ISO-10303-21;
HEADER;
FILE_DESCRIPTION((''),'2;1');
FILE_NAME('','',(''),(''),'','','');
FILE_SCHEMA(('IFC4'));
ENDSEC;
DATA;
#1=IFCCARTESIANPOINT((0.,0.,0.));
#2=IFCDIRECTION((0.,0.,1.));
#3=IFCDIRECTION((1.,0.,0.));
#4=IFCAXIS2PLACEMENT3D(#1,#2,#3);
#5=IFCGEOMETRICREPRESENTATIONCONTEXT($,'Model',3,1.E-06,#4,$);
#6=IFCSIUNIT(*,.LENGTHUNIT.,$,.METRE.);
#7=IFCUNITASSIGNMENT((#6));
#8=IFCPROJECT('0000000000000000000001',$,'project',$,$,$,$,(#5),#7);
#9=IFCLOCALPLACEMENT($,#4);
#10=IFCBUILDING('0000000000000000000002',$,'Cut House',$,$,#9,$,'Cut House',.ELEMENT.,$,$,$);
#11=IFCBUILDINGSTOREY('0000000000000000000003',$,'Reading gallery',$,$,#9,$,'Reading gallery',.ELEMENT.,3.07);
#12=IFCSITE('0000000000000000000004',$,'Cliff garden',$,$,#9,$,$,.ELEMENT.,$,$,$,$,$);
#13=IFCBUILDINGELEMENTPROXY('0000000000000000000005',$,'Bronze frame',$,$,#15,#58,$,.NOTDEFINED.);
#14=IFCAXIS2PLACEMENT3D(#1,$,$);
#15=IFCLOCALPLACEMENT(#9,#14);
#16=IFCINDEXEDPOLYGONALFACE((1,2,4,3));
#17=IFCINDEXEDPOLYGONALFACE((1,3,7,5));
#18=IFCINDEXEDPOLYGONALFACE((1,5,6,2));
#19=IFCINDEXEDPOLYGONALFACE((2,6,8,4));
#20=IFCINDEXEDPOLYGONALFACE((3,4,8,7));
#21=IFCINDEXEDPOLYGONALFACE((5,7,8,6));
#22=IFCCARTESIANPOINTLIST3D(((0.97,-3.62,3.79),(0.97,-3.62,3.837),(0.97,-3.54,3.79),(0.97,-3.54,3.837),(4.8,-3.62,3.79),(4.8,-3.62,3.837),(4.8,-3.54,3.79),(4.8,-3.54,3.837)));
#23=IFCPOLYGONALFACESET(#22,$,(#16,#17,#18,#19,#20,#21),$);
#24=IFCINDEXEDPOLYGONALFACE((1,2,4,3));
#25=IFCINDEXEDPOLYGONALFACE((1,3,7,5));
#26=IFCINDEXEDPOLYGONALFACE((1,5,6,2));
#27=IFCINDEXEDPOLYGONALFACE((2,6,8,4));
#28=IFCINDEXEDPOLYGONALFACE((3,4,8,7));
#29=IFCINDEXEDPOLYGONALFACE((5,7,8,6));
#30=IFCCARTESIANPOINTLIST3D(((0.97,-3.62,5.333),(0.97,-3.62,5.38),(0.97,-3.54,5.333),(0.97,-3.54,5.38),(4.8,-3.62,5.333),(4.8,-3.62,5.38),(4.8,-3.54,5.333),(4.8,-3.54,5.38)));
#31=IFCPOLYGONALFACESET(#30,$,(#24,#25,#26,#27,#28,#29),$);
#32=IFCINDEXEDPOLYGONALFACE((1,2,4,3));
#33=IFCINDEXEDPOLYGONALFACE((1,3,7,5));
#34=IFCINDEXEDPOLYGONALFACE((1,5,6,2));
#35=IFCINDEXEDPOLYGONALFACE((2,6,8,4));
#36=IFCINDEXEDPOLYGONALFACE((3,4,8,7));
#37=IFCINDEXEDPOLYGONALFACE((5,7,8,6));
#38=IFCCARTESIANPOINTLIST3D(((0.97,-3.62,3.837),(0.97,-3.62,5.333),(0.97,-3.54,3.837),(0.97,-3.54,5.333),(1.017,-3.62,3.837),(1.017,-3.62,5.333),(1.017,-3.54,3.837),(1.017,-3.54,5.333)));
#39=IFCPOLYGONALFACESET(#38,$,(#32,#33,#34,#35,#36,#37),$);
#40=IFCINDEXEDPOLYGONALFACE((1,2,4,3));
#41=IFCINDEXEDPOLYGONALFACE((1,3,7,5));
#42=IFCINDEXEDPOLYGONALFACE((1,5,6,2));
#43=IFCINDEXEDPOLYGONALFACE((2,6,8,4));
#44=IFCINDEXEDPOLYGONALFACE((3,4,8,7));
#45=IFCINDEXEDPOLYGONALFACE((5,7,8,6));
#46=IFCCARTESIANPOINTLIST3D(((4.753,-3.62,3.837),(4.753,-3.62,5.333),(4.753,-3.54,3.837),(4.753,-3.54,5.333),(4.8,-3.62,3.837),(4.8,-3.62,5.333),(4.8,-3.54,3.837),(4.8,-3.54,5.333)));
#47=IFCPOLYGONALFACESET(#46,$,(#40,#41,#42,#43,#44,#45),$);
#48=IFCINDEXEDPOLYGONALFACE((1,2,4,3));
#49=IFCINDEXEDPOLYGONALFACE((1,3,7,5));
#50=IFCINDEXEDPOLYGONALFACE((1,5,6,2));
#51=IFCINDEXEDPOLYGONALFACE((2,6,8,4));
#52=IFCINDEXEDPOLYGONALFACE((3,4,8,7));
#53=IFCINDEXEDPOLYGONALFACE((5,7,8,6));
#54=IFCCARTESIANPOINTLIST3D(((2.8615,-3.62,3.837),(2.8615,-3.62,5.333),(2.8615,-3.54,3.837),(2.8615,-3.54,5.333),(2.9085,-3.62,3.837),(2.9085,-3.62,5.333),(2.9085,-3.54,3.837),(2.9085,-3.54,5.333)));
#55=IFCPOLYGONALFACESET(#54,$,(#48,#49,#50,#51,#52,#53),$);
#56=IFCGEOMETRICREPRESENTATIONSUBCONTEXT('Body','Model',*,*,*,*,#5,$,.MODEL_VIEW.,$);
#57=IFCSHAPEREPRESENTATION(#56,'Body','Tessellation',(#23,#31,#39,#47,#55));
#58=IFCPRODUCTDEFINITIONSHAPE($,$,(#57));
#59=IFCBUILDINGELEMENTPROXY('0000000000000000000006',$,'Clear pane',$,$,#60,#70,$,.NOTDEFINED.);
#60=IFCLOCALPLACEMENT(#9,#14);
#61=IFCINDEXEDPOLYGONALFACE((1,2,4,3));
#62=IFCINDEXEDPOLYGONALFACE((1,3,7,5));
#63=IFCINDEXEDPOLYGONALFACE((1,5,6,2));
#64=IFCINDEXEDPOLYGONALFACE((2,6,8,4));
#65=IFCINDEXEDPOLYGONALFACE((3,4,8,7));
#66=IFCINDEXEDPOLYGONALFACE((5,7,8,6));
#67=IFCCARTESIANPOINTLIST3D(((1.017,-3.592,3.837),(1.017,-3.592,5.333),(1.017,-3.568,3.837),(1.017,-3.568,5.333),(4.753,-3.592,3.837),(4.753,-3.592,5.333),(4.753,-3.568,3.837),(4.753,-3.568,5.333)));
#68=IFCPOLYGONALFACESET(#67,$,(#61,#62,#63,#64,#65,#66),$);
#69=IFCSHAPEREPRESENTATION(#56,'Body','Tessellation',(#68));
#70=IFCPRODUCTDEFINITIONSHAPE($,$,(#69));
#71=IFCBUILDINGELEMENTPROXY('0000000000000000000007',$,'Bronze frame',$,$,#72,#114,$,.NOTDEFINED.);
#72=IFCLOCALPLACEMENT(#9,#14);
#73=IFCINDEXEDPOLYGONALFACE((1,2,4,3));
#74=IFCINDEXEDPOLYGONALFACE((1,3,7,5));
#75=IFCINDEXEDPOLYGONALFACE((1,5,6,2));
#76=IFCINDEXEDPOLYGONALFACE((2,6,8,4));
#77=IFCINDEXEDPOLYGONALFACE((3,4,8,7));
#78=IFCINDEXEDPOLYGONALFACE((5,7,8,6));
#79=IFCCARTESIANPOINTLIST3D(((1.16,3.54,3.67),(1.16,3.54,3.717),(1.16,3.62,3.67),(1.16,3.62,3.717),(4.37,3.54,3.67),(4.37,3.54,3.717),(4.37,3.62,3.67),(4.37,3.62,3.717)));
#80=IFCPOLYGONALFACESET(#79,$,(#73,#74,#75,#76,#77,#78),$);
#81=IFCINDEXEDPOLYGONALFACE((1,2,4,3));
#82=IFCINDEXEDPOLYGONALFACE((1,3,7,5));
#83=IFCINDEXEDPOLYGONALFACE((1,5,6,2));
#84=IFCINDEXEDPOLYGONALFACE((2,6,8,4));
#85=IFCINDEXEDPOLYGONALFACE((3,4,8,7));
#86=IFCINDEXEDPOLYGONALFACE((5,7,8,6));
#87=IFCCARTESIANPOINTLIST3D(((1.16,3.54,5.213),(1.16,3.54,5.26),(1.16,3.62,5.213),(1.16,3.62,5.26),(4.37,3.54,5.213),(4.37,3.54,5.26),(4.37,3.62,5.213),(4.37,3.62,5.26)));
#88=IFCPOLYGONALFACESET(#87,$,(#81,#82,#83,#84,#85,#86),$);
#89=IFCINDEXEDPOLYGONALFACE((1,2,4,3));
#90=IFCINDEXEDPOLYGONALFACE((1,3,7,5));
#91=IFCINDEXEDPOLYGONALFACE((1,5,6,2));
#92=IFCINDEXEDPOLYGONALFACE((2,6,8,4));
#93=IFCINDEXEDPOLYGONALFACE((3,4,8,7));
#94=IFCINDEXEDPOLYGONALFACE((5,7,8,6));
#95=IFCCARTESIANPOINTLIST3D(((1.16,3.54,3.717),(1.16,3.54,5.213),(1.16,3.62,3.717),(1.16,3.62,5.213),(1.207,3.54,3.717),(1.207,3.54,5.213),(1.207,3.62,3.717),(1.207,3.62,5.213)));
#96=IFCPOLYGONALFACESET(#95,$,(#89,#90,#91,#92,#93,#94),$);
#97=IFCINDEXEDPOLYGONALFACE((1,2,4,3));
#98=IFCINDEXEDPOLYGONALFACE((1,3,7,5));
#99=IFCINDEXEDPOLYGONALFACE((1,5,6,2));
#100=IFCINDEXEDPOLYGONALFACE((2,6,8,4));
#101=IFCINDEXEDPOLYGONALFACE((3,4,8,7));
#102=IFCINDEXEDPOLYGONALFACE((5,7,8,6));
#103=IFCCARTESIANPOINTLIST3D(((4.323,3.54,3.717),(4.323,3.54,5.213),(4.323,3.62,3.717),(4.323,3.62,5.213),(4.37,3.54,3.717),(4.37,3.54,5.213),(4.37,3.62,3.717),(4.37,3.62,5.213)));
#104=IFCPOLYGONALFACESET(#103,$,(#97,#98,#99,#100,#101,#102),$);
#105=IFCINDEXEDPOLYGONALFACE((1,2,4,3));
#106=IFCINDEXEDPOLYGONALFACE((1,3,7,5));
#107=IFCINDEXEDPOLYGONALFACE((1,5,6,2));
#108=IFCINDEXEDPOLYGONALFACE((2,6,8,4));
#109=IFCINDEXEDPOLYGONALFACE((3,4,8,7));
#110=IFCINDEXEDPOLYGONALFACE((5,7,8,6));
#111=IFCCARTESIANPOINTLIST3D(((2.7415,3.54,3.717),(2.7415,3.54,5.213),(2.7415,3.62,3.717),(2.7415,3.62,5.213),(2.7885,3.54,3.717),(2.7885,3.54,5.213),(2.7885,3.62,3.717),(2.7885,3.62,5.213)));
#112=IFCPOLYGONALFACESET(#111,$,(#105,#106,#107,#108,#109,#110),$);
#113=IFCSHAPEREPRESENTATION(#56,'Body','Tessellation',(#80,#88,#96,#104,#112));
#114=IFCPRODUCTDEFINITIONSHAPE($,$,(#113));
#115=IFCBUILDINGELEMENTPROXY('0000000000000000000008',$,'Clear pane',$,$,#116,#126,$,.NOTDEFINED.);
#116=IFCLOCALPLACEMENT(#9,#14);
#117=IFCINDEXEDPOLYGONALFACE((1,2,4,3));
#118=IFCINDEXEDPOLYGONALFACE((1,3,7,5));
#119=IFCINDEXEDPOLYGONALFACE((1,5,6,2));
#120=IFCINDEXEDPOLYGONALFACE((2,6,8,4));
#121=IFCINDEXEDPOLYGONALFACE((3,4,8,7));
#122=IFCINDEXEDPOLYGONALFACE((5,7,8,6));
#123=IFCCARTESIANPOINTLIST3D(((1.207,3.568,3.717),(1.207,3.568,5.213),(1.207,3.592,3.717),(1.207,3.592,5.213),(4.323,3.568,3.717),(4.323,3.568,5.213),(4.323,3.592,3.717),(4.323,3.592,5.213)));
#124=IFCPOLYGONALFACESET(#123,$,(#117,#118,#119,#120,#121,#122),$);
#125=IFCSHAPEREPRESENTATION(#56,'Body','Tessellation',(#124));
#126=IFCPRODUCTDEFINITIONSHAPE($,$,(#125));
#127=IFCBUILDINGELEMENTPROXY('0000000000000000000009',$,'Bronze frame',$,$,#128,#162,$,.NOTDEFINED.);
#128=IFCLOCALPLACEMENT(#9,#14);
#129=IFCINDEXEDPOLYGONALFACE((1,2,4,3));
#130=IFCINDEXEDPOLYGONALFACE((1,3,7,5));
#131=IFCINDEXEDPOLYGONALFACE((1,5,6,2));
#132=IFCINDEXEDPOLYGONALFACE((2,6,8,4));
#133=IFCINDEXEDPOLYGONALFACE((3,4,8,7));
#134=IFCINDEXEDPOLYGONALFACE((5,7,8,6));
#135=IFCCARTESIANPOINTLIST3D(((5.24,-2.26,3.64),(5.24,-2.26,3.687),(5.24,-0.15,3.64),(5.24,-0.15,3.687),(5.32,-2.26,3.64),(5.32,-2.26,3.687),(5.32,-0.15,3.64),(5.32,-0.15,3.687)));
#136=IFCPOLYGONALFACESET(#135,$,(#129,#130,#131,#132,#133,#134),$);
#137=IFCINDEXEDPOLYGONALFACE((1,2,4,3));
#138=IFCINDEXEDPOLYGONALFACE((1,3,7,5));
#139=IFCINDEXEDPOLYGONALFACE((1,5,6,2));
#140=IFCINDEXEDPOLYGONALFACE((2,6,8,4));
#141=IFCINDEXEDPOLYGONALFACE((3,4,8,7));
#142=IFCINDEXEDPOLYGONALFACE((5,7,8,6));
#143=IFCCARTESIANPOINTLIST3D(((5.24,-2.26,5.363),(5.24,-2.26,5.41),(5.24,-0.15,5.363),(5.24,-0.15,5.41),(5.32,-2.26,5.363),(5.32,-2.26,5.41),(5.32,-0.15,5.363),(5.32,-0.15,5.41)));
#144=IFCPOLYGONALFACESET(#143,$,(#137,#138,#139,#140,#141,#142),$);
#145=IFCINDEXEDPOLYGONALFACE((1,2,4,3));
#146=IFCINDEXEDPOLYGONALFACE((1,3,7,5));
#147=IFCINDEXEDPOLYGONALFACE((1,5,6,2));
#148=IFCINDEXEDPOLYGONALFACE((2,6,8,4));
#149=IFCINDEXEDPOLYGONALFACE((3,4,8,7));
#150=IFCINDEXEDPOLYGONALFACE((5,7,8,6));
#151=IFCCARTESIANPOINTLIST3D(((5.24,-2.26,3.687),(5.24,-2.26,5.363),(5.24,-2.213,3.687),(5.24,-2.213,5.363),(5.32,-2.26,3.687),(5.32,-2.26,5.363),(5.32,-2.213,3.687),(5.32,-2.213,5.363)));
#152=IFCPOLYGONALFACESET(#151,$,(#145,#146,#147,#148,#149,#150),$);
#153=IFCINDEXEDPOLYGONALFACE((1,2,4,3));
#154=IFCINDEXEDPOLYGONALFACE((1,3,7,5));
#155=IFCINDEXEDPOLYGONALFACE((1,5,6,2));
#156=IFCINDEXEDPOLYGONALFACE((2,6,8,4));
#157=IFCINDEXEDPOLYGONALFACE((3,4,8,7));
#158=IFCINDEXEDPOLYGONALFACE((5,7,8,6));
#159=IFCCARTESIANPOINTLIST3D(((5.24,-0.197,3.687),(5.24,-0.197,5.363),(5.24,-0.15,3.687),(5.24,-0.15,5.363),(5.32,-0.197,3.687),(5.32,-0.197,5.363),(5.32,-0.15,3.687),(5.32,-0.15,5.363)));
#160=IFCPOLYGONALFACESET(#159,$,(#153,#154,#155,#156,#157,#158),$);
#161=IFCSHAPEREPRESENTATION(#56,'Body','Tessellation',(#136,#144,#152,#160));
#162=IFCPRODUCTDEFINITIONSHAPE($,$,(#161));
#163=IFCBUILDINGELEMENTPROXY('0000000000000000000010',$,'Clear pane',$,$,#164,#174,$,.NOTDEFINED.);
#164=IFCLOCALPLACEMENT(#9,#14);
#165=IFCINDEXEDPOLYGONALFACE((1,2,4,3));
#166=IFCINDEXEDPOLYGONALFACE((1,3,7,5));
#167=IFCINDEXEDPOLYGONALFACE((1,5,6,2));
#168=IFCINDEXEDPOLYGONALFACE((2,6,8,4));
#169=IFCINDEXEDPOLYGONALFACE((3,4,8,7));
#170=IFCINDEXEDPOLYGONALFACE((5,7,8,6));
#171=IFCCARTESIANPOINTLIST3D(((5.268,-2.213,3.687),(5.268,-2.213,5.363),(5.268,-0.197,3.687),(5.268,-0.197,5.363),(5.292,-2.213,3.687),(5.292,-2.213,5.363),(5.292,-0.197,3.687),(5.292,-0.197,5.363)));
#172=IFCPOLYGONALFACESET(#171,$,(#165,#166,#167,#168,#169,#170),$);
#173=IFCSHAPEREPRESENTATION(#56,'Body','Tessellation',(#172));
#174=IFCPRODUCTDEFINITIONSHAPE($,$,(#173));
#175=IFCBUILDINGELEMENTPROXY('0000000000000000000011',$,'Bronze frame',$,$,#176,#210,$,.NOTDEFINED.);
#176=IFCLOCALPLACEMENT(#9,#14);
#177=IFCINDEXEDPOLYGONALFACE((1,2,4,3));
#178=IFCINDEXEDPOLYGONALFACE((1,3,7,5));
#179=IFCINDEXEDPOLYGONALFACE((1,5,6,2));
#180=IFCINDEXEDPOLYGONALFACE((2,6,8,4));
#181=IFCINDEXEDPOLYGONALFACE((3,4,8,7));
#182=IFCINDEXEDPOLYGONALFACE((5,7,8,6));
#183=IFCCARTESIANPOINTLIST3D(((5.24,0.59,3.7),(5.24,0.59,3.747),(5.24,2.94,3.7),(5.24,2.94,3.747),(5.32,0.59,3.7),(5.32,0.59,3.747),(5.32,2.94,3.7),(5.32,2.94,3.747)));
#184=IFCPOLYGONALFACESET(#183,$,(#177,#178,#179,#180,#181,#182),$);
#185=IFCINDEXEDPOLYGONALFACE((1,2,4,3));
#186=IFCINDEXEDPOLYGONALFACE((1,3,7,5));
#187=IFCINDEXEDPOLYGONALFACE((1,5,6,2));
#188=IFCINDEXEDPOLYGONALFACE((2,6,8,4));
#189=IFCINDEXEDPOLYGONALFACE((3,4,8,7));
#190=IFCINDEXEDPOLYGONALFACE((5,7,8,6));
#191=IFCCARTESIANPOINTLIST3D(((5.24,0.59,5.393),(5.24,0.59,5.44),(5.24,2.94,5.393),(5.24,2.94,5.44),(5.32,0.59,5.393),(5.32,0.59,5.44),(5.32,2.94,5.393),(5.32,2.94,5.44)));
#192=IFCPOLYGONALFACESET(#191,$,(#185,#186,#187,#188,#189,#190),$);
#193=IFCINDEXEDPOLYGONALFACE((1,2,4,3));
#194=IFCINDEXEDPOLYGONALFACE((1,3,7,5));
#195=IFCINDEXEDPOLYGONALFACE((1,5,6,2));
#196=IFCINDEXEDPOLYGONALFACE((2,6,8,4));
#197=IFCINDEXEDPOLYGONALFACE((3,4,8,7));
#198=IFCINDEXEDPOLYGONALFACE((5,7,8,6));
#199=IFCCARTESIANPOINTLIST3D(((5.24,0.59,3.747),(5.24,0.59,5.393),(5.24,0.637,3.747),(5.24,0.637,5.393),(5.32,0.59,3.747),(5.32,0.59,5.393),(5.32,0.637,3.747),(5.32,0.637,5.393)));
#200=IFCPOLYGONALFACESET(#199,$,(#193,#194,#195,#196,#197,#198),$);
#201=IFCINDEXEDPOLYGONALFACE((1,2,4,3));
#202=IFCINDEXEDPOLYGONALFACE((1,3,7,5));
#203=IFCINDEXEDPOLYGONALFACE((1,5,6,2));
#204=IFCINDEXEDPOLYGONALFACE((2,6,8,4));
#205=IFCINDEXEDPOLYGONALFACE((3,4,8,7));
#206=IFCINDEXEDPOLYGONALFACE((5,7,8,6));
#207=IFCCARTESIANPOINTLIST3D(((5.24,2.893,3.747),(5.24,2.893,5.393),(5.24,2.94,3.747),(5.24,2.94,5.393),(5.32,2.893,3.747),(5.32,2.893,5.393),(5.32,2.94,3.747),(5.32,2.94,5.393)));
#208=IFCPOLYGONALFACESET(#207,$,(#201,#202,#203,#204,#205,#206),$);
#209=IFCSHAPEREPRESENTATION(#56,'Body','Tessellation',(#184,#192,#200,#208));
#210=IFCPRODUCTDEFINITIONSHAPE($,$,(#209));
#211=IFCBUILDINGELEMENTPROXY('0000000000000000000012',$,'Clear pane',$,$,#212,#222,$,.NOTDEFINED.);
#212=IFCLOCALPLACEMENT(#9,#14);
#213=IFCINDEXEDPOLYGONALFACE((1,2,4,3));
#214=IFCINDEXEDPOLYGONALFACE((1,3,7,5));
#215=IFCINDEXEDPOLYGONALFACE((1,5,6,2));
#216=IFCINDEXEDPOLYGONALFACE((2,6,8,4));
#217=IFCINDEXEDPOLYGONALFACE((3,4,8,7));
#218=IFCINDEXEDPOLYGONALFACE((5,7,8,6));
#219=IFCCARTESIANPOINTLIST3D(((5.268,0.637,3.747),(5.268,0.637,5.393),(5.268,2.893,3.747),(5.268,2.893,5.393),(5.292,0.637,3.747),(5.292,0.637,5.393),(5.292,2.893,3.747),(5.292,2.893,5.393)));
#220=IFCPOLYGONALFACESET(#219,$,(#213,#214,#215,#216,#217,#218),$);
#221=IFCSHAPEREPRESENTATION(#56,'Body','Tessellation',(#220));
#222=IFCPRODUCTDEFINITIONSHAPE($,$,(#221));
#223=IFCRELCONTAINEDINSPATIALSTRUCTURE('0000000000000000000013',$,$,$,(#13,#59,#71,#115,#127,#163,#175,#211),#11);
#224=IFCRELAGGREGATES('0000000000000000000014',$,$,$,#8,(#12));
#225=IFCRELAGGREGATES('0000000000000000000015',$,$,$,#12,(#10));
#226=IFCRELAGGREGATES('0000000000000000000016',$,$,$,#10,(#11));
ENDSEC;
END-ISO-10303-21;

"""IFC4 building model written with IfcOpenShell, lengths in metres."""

from ifc_helpers import new_model, si_unit, frame, origin_with_axes, place, context, subcontext, project, spatial, polyline, outline, extrude, element, save


model = new_model("IFC4")

# Units and contexts
model_context = context("Model", 3, precision=1e-06, world=origin_with_axes())
body_context = subcontext(model_context, "Body", "Model", "MODEL_VIEW")
ifc_project = project(units=[si_unit("LENGTHUNIT", "METRE")], contexts=[model_context])

# Site, building, storey
placement = place(None, origin_with_axes())
site = spatial("IfcSite", under=ifc_project, at=placement, Name="Cliff garden", CompositionType="ELEMENT")
building = spatial("IfcBuilding", under=site, at=placement, Name="Cut House", LongName="Cut House", CompositionType="ELEMENT")
storey = spatial("IfcBuildingStorey", under=building, at=placement, Name="Reading gallery", LongName="Reading gallery", CompositionType="ELEMENT", Elevation=3.07)

# Building element proxies
element("IfcBuildingElementProxy", 1, at=placement, inside=storey, Name="Bronze frame", PredefinedType="NOTDEFINED", context=body_context, shape_type="SweptSolid", body=[
    extrude(outline(polyline([(0.0, 0.0), (3.83, 0.0), (3.83, 0.08), (0.0, 0.08), (0.0, 0.0)])), frame((0.97, -3.62, 3.79), z_axis=(0.0, 0.0, 1.0), x_axis=(1.0, 0.0, 0.0)), (0.0, 0.0, 1.0), 0.047),
    extrude(outline(polyline([(0.0, 0.0), (3.83, 0.0), (3.83, 0.08), (0.0, 0.08), (0.0, 0.0)])), frame((0.97, -3.62, 5.333), z_axis=(0.0, 0.0, 1.0), x_axis=(1.0, 0.0, 0.0)), (0.0, 0.0, 1.0), 0.047),
    extrude(outline(polyline([(0.0, 0.0), (0.047, 0.0), (0.047, 0.08), (0.0, 0.08), (0.0, 0.0)])), frame((0.97, -3.62, 3.837), z_axis=(0.0, 0.0, 1.0), x_axis=(1.0, 0.0, 0.0)), (0.0, 0.0, 1.0), 1.496),
    extrude(outline(polyline([(0.0, 0.0), (0.047, 0.0), (0.047, 0.08), (0.0, 0.08), (0.0, 0.0)])), frame((4.753, -3.62, 3.837), z_axis=(0.0, 0.0, 1.0), x_axis=(1.0, 0.0, 0.0)), (0.0, 0.0, 1.0), 1.496),
    extrude(outline(polyline([(0.0, 0.0), (0.047, 0.0), (0.047, 0.08), (0.0, 0.08), (0.0, 0.0)])), frame((2.8615, -3.62, 3.837), z_axis=(0.0, 0.0, 1.0), x_axis=(1.0, 0.0, 0.0)), (0.0, 0.0, 1.0), 1.496),
])
element("IfcBuildingElementProxy", 2, at=placement, inside=storey, Name="Clear pane", PredefinedType="NOTDEFINED", context=body_context, shape_type="SweptSolid", body=[
    extrude(outline(polyline([(0.0, 0.0), (3.736, 0.0), (3.736, 0.024), (0.0, 0.024), (0.0, 0.0)])), frame((1.017, -3.592, 3.837), z_axis=(0.0, 0.0, 1.0), x_axis=(1.0, 0.0, 0.0)), (0.0, 0.0, 1.0), 1.496),
])
element("IfcBuildingElementProxy", 3, at=placement, inside=storey, Name="Bronze frame", PredefinedType="NOTDEFINED", context=body_context, shape_type="SweptSolid", body=[
    extrude(outline(polyline([(0.0, 0.0), (3.21, 0.0), (3.21, 0.08), (0.0, 0.08), (0.0, 0.0)])), frame((1.16, 3.54, 3.67), z_axis=(0.0, 0.0, 1.0), x_axis=(1.0, 0.0, 0.0)), (0.0, 0.0, 1.0), 0.047),
    extrude(outline(polyline([(0.0, 0.0), (3.21, 0.0), (3.21, 0.08), (0.0, 0.08), (0.0, 0.0)])), frame((1.16, 3.54, 5.213), z_axis=(0.0, 0.0, 1.0), x_axis=(1.0, 0.0, 0.0)), (0.0, 0.0, 1.0), 0.047),
    extrude(outline(polyline([(0.0, 0.0), (0.047, 0.0), (0.047, 0.08), (0.0, 0.08), (0.0, 0.0)])), frame((1.16, 3.54, 3.717), z_axis=(0.0, 0.0, 1.0), x_axis=(1.0, 0.0, 0.0)), (0.0, 0.0, 1.0), 1.496),
    extrude(outline(polyline([(0.0, 0.0), (0.047, 0.0), (0.047, 0.08), (0.0, 0.08), (0.0, 0.0)])), frame((4.323, 3.54, 3.717), z_axis=(0.0, 0.0, 1.0), x_axis=(1.0, 0.0, 0.0)), (0.0, 0.0, 1.0), 1.496),
    extrude(outline(polyline([(0.0, 0.0), (0.047, 0.0), (0.047, 0.08), (0.0, 0.08), (0.0, 0.0)])), frame((2.7415, 3.54, 3.717), z_axis=(0.0, 0.0, 1.0), x_axis=(1.0, 0.0, 0.0)), (0.0, 0.0, 1.0), 1.496),
])
element("IfcBuildingElementProxy", 4, at=placement, inside=storey, Name="Clear pane", PredefinedType="NOTDEFINED", context=body_context, shape_type="SweptSolid", body=[
    extrude(outline(polyline([(0.0, 0.0), (3.116, 0.0), (3.116, 0.024), (0.0, 0.024), (0.0, 0.0)])), frame((1.207, 3.568, 3.717), z_axis=(0.0, 0.0, 1.0), x_axis=(1.0, 0.0, 0.0)), (0.0, 0.0, 1.0), 1.496),
])
element("IfcBuildingElementProxy", 5, at=placement, inside=storey, Name="Bronze frame", PredefinedType="NOTDEFINED", context=body_context, shape_type="SweptSolid", body=[
    extrude(outline(polyline([(0.0, 0.0), (0.08, 0.0), (0.08, 2.11), (0.0, 2.11), (0.0, 0.0)])), frame((5.24, -2.26, 3.64), z_axis=(0.0, 0.0, 1.0), x_axis=(1.0, 0.0, 0.0)), (0.0, 0.0, 1.0), 0.047),
    extrude(outline(polyline([(0.0, 0.0), (0.08, 0.0), (0.08, 2.11), (0.0, 2.11), (0.0, 0.0)])), frame((5.24, -2.26, 5.363), z_axis=(0.0, 0.0, 1.0), x_axis=(1.0, 0.0, 0.0)), (0.0, 0.0, 1.0), 0.047),
    extrude(outline(polyline([(0.0, 0.0), (0.08, 0.0), (0.08, 0.047), (0.0, 0.047), (0.0, 0.0)])), frame((5.24, -2.26, 3.687), z_axis=(0.0, 0.0, 1.0), x_axis=(1.0, 0.0, 0.0)), (0.0, 0.0, 1.0), 1.676),
    extrude(outline(polyline([(0.0, 0.0), (0.08, 0.0), (0.08, 0.047), (0.0, 0.047), (0.0, 0.0)])), frame((5.24, -0.197, 3.687), z_axis=(0.0, 0.0, 1.0), x_axis=(1.0, 0.0, 0.0)), (0.0, 0.0, 1.0), 1.676),
])
element("IfcBuildingElementProxy", 6, at=placement, inside=storey, Name="Clear pane", PredefinedType="NOTDEFINED", context=body_context, shape_type="SweptSolid", body=[
    extrude(outline(polyline([(0.0, 0.0), (0.024, 0.0), (0.024, 2.016), (0.0, 2.016), (0.0, 0.0)])), frame((5.268, -2.213, 3.687), z_axis=(0.0, 0.0, 1.0), x_axis=(1.0, 0.0, 0.0)), (0.0, 0.0, 1.0), 1.676),
])
element("IfcBuildingElementProxy", 7, at=placement, inside=storey, Name="Bronze frame", PredefinedType="NOTDEFINED", context=body_context, shape_type="SweptSolid", body=[
    extrude(outline(polyline([(0.0, 0.0), (0.08, 0.0), (0.08, 2.35), (0.0, 2.35), (0.0, 0.0)])), frame((5.24, 0.59, 3.7), z_axis=(0.0, 0.0, 1.0), x_axis=(1.0, 0.0, 0.0)), (0.0, 0.0, 1.0), 0.047),
    extrude(outline(polyline([(0.0, 0.0), (0.08, 0.0), (0.08, 2.35), (0.0, 2.35), (0.0, 0.0)])), frame((5.24, 0.59, 5.393), z_axis=(0.0, 0.0, 1.0), x_axis=(1.0, 0.0, 0.0)), (0.0, 0.0, 1.0), 0.047),
    extrude(outline(polyline([(0.0, 0.0), (0.08, 0.0), (0.08, 0.047), (0.0, 0.047), (0.0, 0.0)])), frame((5.24, 0.59, 3.747), z_axis=(0.0, 0.0, 1.0), x_axis=(1.0, 0.0, 0.0)), (0.0, 0.0, 1.0), 1.646),
    extrude(outline(polyline([(0.0, 0.0), (0.08, 0.0), (0.08, 0.047), (0.0, 0.047), (0.0, 0.0)])), frame((5.24, 2.893, 3.747), z_axis=(0.0, 0.0, 1.0), x_axis=(1.0, 0.0, 0.0)), (0.0, 0.0, 1.0), 1.646),
])
element("IfcBuildingElementProxy", 8, at=placement, inside=storey, Name="Clear pane", PredefinedType="NOTDEFINED", context=body_context, shape_type="SweptSolid", body=[
    extrude(outline(polyline([(0.0, 0.0), (0.024, 0.0), (0.024, 2.256), (0.0, 2.256), (0.0, 0.0)])), frame((5.268, 0.637, 3.747), z_axis=(0.0, 0.0, 1.0), x_axis=(1.0, 0.0, 0.0)), (0.0, 0.0, 1.0), 1.646),
])

save(model, "model.ifc")
